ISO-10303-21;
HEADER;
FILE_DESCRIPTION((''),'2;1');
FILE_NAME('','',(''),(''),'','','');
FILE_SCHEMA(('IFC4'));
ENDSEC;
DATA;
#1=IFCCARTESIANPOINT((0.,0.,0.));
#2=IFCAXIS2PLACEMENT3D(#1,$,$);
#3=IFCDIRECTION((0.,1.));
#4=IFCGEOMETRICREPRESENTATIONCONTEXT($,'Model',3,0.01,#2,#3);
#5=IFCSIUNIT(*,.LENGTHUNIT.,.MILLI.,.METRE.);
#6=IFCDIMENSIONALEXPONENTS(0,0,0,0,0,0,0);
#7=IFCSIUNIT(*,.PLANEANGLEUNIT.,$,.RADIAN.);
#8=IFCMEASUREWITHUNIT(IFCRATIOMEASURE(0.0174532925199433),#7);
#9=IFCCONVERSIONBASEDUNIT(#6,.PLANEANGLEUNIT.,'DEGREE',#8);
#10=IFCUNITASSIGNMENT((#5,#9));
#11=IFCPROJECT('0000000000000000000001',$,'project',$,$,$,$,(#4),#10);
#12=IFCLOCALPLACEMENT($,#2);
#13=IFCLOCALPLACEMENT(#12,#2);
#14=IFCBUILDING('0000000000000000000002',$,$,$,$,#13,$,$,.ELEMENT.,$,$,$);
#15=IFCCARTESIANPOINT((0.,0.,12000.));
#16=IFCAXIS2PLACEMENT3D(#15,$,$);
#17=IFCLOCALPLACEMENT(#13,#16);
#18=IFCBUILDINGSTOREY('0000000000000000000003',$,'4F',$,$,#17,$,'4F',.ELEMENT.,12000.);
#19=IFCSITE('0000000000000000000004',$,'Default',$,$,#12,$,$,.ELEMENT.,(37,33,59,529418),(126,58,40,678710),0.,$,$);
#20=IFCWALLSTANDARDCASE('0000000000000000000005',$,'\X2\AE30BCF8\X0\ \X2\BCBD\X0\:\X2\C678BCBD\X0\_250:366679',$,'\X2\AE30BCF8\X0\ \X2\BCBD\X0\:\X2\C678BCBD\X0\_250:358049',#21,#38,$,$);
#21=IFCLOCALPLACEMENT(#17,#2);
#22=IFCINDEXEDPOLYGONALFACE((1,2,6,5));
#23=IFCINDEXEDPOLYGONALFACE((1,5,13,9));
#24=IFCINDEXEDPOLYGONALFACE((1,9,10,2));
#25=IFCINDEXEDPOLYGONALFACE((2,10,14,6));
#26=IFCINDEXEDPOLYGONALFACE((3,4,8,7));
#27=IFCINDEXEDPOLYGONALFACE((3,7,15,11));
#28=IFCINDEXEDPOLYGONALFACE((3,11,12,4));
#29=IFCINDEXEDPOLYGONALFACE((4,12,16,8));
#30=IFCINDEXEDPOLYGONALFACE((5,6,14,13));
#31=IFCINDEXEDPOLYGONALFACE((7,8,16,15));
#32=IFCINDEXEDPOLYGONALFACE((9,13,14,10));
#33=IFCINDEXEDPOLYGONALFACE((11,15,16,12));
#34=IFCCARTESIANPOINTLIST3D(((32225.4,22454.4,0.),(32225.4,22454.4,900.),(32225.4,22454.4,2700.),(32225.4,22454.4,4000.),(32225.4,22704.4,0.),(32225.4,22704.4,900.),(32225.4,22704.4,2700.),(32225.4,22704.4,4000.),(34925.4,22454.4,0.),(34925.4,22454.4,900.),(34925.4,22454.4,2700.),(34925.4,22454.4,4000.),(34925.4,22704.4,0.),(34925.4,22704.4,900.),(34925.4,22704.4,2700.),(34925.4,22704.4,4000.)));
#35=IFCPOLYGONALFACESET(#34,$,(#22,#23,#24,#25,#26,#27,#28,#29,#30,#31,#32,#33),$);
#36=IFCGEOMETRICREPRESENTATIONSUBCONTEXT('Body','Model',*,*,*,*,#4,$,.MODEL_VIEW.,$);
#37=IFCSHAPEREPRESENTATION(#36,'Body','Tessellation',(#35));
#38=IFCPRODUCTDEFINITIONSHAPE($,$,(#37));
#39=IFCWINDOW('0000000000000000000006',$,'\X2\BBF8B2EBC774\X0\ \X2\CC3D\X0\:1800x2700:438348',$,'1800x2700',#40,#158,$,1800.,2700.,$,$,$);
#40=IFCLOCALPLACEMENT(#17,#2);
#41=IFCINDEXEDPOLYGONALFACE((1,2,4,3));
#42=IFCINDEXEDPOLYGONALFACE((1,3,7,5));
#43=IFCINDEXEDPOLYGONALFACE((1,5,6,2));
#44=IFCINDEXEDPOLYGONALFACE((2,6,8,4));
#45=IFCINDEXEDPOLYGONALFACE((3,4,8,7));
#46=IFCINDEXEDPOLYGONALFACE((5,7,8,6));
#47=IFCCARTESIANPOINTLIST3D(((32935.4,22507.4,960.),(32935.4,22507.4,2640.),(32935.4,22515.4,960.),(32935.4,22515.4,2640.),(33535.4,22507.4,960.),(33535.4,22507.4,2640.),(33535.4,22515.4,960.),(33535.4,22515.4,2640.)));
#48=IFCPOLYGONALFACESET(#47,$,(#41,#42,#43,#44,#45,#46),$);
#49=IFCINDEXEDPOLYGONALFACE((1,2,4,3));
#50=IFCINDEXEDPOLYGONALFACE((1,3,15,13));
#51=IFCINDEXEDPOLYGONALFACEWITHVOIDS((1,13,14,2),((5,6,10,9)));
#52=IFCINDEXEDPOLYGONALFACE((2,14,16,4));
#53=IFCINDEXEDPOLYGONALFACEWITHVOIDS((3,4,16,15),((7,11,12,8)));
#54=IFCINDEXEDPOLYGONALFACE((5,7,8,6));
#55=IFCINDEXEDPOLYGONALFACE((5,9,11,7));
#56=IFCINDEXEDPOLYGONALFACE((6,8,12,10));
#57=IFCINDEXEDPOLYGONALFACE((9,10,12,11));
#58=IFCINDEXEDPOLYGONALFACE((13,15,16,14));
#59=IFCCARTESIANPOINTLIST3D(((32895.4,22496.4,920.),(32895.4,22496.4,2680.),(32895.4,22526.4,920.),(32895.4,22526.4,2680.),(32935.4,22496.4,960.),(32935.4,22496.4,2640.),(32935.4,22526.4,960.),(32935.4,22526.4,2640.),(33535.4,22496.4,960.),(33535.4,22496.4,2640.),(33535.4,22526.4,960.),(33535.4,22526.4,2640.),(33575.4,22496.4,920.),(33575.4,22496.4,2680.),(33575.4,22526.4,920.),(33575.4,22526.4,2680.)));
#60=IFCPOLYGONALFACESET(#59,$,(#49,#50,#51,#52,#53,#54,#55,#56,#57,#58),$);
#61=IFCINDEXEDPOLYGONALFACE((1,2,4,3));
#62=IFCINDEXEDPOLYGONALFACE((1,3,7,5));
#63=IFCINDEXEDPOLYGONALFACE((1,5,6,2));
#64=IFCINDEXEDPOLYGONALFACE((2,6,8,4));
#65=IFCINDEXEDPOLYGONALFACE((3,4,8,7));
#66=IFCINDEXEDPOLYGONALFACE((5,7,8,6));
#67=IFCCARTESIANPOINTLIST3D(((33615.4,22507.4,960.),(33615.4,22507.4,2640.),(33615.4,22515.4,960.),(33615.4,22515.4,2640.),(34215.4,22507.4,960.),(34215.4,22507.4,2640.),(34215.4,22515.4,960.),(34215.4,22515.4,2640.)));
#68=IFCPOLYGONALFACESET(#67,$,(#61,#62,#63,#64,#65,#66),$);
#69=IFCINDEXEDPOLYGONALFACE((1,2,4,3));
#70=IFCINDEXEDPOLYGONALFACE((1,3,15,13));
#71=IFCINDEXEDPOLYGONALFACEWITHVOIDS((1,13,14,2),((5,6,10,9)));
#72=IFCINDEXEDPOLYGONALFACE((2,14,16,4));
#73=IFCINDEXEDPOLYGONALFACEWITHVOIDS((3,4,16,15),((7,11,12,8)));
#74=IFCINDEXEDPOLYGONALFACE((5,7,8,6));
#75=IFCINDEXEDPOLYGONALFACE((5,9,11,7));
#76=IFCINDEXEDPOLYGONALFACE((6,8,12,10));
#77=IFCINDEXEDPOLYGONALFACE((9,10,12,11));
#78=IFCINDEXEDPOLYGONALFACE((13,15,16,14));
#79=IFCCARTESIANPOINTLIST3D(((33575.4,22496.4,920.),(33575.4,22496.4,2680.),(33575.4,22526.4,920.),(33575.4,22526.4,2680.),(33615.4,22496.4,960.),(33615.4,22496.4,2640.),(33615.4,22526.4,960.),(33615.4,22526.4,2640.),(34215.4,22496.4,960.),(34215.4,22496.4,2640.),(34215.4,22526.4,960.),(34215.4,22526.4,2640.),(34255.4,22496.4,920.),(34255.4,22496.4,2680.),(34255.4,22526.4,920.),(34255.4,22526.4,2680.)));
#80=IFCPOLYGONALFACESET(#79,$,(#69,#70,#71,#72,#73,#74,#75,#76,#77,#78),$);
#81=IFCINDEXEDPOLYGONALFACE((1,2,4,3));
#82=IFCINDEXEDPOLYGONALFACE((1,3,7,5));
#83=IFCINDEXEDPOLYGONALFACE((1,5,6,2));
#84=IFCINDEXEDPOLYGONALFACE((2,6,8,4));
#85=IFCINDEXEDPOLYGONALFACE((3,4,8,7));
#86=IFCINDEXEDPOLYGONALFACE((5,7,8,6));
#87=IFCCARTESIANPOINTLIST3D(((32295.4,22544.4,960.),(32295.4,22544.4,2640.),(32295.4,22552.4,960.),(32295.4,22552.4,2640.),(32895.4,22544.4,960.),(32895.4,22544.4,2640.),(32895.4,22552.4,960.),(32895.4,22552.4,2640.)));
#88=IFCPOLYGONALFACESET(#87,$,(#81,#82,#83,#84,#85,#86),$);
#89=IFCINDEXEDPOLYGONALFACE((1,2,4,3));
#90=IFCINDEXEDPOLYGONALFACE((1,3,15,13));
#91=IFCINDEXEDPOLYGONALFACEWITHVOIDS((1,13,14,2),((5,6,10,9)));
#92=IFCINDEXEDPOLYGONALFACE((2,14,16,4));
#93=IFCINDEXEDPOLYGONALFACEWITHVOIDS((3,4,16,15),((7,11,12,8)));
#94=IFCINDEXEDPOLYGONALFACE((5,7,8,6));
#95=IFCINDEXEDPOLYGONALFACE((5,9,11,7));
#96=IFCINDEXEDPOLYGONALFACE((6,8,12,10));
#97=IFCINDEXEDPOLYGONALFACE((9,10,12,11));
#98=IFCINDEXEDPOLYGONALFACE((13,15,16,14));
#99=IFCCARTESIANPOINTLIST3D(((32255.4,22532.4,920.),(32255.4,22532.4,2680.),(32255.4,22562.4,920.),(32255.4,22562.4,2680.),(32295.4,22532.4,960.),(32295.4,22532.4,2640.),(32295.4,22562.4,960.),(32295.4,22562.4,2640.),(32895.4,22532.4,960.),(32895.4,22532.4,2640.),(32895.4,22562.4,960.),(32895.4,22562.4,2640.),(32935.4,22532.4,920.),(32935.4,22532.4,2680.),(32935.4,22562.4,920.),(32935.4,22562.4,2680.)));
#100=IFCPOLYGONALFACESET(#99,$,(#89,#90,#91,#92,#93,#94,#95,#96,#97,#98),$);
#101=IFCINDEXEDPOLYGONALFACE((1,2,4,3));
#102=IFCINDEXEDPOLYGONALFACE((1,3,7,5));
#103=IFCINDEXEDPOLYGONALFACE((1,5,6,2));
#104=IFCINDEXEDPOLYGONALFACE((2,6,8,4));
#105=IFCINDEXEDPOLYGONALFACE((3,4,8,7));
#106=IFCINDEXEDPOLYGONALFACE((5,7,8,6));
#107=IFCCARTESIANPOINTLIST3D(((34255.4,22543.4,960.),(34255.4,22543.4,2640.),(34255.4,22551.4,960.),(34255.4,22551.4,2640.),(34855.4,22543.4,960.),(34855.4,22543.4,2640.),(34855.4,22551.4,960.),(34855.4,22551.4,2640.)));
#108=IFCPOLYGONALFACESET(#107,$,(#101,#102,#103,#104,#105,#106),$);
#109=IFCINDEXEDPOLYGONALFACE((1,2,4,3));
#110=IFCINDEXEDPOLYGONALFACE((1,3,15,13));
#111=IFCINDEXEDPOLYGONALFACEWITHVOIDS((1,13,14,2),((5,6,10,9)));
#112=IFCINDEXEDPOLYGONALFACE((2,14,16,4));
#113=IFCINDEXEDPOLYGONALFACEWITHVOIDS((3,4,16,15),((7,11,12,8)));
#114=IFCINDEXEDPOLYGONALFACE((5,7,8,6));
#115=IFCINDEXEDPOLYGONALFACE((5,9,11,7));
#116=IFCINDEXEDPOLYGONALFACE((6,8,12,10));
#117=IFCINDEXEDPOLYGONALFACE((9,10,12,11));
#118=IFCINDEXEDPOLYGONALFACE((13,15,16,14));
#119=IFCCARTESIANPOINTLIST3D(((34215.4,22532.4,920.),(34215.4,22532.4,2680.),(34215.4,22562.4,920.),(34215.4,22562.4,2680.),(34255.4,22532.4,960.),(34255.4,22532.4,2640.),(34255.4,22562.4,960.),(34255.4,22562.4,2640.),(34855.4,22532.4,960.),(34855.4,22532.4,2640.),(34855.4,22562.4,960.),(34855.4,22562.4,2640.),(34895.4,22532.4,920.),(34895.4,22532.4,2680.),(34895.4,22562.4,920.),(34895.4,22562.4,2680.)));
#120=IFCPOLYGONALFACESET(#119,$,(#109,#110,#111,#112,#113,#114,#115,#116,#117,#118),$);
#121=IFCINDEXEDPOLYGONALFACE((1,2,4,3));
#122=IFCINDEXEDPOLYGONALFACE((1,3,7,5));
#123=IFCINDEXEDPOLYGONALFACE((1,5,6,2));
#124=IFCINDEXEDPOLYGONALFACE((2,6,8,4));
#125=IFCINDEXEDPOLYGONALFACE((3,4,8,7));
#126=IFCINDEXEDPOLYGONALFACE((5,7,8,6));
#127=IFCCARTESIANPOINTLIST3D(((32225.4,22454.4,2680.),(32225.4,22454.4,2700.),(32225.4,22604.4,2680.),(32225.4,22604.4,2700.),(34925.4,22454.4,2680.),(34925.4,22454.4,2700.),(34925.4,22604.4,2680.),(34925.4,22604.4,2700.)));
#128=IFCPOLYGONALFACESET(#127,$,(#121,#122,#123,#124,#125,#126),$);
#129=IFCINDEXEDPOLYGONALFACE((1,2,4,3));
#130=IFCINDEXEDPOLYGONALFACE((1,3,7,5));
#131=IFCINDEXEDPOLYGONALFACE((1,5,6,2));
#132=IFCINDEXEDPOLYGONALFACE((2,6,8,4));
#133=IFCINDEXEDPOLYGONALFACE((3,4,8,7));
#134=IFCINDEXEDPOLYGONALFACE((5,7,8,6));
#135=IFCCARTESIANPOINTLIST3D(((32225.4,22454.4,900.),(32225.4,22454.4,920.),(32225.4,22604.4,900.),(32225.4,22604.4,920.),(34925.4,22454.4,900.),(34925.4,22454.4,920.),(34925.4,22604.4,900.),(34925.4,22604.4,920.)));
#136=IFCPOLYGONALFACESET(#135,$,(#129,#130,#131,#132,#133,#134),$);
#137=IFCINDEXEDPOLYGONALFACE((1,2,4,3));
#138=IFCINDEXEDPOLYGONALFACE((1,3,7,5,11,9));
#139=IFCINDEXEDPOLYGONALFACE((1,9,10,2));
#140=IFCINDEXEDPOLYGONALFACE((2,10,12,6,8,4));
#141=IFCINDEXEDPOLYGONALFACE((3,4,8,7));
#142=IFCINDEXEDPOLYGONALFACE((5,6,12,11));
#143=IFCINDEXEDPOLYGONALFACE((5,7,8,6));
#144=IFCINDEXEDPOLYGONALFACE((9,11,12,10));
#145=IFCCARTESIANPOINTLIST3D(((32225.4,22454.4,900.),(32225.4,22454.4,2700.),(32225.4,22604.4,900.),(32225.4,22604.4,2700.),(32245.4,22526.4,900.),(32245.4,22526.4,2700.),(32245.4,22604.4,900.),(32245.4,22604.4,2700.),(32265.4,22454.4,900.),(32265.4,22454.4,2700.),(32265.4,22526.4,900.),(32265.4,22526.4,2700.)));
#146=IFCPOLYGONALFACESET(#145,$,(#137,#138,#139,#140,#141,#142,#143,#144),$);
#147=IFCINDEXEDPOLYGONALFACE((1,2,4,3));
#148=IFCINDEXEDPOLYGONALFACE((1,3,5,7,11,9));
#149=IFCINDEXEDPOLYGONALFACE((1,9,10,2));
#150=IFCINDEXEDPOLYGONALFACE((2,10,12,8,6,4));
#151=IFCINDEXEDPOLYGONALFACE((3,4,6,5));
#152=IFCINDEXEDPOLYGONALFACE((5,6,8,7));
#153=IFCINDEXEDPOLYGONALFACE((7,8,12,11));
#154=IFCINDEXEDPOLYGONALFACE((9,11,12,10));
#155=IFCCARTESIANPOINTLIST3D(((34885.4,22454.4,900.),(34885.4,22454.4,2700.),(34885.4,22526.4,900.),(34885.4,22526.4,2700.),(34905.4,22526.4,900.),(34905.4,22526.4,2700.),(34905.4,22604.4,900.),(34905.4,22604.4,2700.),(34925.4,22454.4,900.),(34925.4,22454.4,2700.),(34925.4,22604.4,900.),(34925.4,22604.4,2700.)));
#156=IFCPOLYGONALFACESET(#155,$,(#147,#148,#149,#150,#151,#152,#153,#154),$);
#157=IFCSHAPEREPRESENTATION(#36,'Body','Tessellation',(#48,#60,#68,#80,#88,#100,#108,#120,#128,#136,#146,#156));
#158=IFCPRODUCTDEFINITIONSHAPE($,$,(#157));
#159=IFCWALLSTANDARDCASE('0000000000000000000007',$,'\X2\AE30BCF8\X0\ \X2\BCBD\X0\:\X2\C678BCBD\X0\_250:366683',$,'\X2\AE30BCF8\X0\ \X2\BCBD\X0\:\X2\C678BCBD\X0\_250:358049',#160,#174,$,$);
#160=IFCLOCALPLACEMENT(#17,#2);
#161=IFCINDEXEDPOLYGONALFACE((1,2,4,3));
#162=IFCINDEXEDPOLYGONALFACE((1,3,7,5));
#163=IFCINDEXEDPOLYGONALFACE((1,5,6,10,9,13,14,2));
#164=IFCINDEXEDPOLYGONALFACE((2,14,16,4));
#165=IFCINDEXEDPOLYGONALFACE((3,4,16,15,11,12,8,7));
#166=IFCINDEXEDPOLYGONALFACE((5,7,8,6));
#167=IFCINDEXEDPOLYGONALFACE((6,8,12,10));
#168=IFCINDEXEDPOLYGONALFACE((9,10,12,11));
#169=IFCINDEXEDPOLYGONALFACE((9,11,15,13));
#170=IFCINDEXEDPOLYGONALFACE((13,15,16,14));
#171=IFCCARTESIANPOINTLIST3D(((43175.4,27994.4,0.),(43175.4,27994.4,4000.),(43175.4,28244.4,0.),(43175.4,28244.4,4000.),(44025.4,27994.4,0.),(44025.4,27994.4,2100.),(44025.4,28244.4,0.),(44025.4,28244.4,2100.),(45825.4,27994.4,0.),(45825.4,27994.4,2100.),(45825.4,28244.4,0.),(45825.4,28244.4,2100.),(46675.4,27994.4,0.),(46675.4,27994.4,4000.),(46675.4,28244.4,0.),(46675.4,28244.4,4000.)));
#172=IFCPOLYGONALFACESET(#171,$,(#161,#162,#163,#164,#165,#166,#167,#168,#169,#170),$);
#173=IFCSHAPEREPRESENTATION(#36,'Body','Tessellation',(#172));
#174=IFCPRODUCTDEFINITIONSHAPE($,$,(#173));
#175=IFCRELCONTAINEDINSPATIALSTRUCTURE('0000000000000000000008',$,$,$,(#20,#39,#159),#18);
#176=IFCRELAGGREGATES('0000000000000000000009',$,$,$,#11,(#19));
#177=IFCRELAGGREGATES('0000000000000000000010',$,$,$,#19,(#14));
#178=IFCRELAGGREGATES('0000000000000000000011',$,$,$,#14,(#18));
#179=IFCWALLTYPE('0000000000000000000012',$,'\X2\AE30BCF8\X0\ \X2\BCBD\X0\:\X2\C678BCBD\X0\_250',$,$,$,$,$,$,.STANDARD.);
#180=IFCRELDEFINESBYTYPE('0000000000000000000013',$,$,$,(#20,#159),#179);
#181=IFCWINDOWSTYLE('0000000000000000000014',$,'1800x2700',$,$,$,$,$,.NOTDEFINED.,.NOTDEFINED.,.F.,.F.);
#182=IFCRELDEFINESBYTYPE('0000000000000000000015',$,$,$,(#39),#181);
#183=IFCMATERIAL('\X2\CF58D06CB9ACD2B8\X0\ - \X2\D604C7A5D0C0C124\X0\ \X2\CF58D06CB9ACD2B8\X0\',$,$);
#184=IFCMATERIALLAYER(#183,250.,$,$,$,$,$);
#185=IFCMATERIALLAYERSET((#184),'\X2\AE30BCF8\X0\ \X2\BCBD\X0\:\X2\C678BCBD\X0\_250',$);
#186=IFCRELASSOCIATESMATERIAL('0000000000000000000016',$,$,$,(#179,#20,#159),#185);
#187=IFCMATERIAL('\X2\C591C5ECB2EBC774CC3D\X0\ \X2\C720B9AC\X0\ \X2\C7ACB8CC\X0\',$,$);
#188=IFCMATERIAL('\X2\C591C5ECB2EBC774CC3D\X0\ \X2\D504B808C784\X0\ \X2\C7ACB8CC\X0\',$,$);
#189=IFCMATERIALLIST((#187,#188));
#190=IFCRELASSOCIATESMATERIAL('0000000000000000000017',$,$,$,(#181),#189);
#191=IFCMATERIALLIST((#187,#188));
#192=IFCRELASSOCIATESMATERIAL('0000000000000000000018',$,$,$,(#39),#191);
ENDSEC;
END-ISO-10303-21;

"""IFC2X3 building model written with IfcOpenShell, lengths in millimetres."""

from ifc_helpers import new_model, entity, si_unit, converted_unit, direction, frame, frame_2d, origin, origin_2d_with_axis, place, context, subcontext, project, spatial, polyline, rectangle, outline, extrude, source, transform, mapped, material, material_list, layer, layer_set, layer_usage, type_object, type_shapes, element, fill, save


model = new_model("IFC2X3")

# Units and contexts
model_context = context("Model", 3, precision=0.01, world=origin(), true_north=direction((0.0, 1.0)))
body_context = subcontext(model_context, "Body", "Model", "MODEL_VIEW")
ifc_project = project(units=[si_unit("LENGTHUNIT", "METRE", prefix="MILLI"), converted_unit("PLANEANGLEUNIT", "DEGREE", entity("IfcRatioMeasure", 0.0174532925199433), si_unit("PLANEANGLEUNIT", "RADIAN"), dimensions=[0, 0, 0, 0, 0, 0, 0])], contexts=[model_context])

# Site, building, storey
site_placement = place(None, origin())
site = spatial("IfcSite", under=ifc_project, at=site_placement, Name="Default", CompositionType="ELEMENT", RefLatitude=(37, 33, 59, 529418), RefLongitude=(126, 58, 40, 678710), RefElevation=0.0)
building_placement = place(site_placement, origin())
building = spatial("IfcBuilding", under=site, at=building_placement, CompositionType="ELEMENT")
storey_placement = place(building_placement, frame((0.0, 0.0, 12000.0)))
storey = spatial("IfcBuildingStorey", under=building, at=storey_placement, Name="4F", LongName="4F", CompositionType="ELEMENT", Elevation=12000.0)

# Shared definitions
ifc_material_1 = material(Name="콘크리트 - 현장타설 콘크리트")
ifc_material_2 = material(Name="양여닫이창 유리 재료")
ifc_material_3 = material(Name="양여닫이창 프레임 재료")

# Wall, opening, window
ifc_layer_1 = layer(ifc_material_1, 250.0)
ifc_layer_set_1 = layer_set([ifc_layer_1], Name="기본 벽:외벽_250")
ifc_layer_usage_1 = layer_usage(ifc_layer_set_1, "AXIS2", "NEGATIVE", 125.0)
wall_type_1 = type_object("IfcWallType", Name="기본 벽:외벽_250", PredefinedType="STANDARD", material=ifc_layer_set_1)
wall_1_placement = place(storey_placement, frame((34925.4, 22579.4, 0.0), z_axis=(0.0, 0.0, 1.0), x_axis=(-1.0, 0.0, 0.0)))
wall_1 = element("IfcWallStandardCase", 1, at=wall_1_placement, inside=storey, type_object=wall_type_1, material=ifc_layer_usage_1, Name="기본 벽:외벽_250:366679", ObjectType="기본 벽:외벽_250:358049", context=body_context, shape_type="SweptSolid", body=[
    extrude(rectangle(XDim=2700.0, YDim=250.0, at=frame_2d((1350.0, 0.0), x_axis=(-1.0, 0.0))), origin(), (0.0, 0.0, 1.0), 4000.0),
])
opening_1_placement = place(wall_1_placement, frame((0.0, -125.0, 900.0)))
opening_1 = element("IfcOpeningElement", 2, at=opening_1_placement, cuts=wall_1, ObjectType="Opening", context=body_context, shape_type="SweptSolid", body=[
    extrude(rectangle(XDim=1800.0, YDim=2700.0, at=frame_2d((900.0, 1350.0), x_axis=(1.0, 0.0))), frame((0.0, 0.0, 0.0), z_axis=(0.0, 1.0, 0.0), x_axis=(0.0, 0.0, 1.0)), (0.0, 0.0, 1.0), 250.0),
])
ifc_material_list_1 = material_list([ifc_material_2, ifc_material_3])
ifc_material_list_2 = material_list([ifc_material_2, ifc_material_3])
window_style_1 = type_object("IfcWindowStyle", Name="1800x2700", ConstructionType="NOTDEFINED", OperationType="NOTDEFINED", ParameterTakesPrecedence=False, Sizeable=False, material=ifc_material_list_2)
shared_shape_1 = source(origin(), body_context, "Body", "SweptSolid", [
    extrude(rectangle(XDim=8.0, YDim=600.0, at=frame_2d((0.0, 0.0), x_axis=(1.0, 0.0))), frame((1690.0, 193.0, 60.0), z_axis=(0.0, 0.0, 1.0), x_axis=(0.0, 1.0, 0.0)), (0.0, 0.0, 1.0), 1680.0),
    extrude(outline(polyline([(-880.0, -340.0), (880.0, -340.0), (880.0, 340.0), (-880.0, 340.0), (-880.0, -340.0)]), holes=[polyline([(840.0, -300.0), (-840.0, -300.0), (-840.0, 300.0), (840.0, 300.0), (840.0, -300.0)])]), frame((1690.0, 178.0, 900.0), z_axis=(0.0, 1.0, 0.0), x_axis=(0.0, 0.0, -1.0)), (0.0, 0.0, 1.0), 30.0),
    extrude(rectangle(XDim=8.0, YDim=600.0, at=origin_2d_with_axis()), frame((1010.0, 193.0, 60.0), z_axis=(0.0, 0.0, 1.0), x_axis=(0.0, 1.0, 0.0)), (0.0, 0.0, 1.0), 1680.0),
    extrude(outline(polyline([(-880.0, -340.0), (880.0, -340.0), (880.0, 340.0), (-880.0, 340.0), (-880.0, -340.0)]), holes=[polyline([(840.0, -300.0), (-840.0, -300.0), (-840.0, 300.0), (840.0, 300.0), (840.0, -300.0)])]), frame((1010.0, 178.0, 900.0), z_axis=(0.0, 1.0, 0.0), x_axis=(0.0, 0.0, -1.0)), (0.0, 0.0, 1.0), 30.0),
    extrude(rectangle(XDim=8.0, YDim=600.0, at=frame_2d((0.0, 0.0), x_axis=(1.0, 0.0))), frame((2330.0, 156.0, 60.0), z_axis=(0.0, 0.0, 1.0), x_axis=(0.0, 1.0, 0.0)), (0.0, 0.0, 1.0), 1680.0),
    extrude(outline(polyline([(-880.0, -340.0), (880.0, -340.0), (880.0, 340.0), (-880.0, 340.0), (-880.0, -340.0)]), holes=[polyline([(840.0, -300.0), (-840.0, -300.0), (-840.0, 300.0), (840.0, 300.0), (840.0, -300.0)])]), frame((2330.0, 142.0, 900.0), z_axis=(0.0, 1.0, 0.0), x_axis=(0.0, 0.0, -1.0)), (0.0, 0.0, 1.0), 30.0),
    extrude(rectangle(XDim=8.0, YDim=600.0, at=frame_2d((0.0, 0.0), x_axis=(1.0, 0.0))), frame((370.0, 157.0, 60.0), z_axis=(0.0, 0.0, 1.0), x_axis=(0.0, 1.0, 0.0)), (0.0, 0.0, 1.0), 1680.0),
    extrude(outline(polyline([(-880.0, -340.0), (880.0, -340.0), (880.0, 340.0), (-880.0, 340.0), (-880.0, -340.0)]), holes=[polyline([(840.0, -300.0), (-840.0, -300.0), (-840.0, 300.0), (840.0, 300.0), (840.0, -300.0)])]), frame((370.0, 142.0, 900.0), z_axis=(0.0, 1.0, 0.0), x_axis=(0.0, 0.0, -1.0)), (0.0, 0.0, 1.0), 30.0),
    extrude(rectangle(XDim=2700.0, YDim=150.0, at=origin_2d_with_axis()), frame((1350.0, 175.0, 1780.0), z_axis=(0.0, 0.0, 1.0), x_axis=(-1.0, 0.0, 0.0)), (0.0, 0.0, 1.0), 20.0),
    extrude(rectangle(XDim=2700.0, YDim=150.0, at=origin_2d_with_axis()), frame((1350.0, 175.0, 0.0), z_axis=(0.0, 0.0, 1.0), x_axis=(-1.0, 0.0, 0.0)), (0.0, 0.0, 1.0), 20.0),
    extrude(outline(polyline([(-74.0, -20.0), (-2.0, -20.0), (-2.0, 0.0), (76.0, 0.0), (76.0, 20.0), (-74.0, 20.0), (-74.0, -20.0)])), frame((2680.0, 176.0, 0.0), z_axis=(0.0, 0.0, 1.0), x_axis=(0.0, -1.0, 0.0)), (0.0, 0.0, 1.0), 1800.0),
    extrude(outline(polyline([(-20.0, -74.0), (20.0, -74.0), (20.0, 76.0), (0.0, 76.0), (0.0, -2.0), (-20.0, -2.0), (-20.0, -74.0)])), frame((20.0, 176.0, 0.0), z_axis=(0.0, 0.0, 1.0), x_axis=(-1.0, 0.0, 0.0)), (0.0, 0.0, 1.0), 1800.0),
])
type_shapes(window_style_1, [shared_shape_1])
window_1_placement = place(opening_1_placement, origin())
window_1 = element("IfcWindow", 3, at=window_1_placement, inside=storey, type_object=window_style_1, material=ifc_material_list_1, Name="미닫이 창:1800x2700:438348", ObjectType="1800x2700", OverallHeight=1800.0, OverallWidth=2700.0, context=body_context, shape_type="MappedRepresentation", body=[
    mapped(shared_shape_1, transform((0.0, 0.0, 0.0), scale=1.0)),
])
fill(opening_1, window_1)

# Wall, opening
ifc_layer_usage_2 = layer_usage(ifc_layer_set_1, "AXIS2", "NEGATIVE", 125.0)
wall_2_placement = place(storey_placement, frame((46675.4, 28119.4, 0.0), z_axis=(0.0, 0.0, 1.0), x_axis=(-1.0, 0.0, 0.0)))
wall_2 = element("IfcWallStandardCase", 4, at=wall_2_placement, inside=storey, type_object=wall_type_1, material=ifc_layer_usage_2, Name="기본 벽:외벽_250:366683", ObjectType="기본 벽:외벽_250:358049", context=body_context, shape_type="SweptSolid", body=[
    extrude(rectangle(XDim=3500.0, YDim=250.0, at=frame_2d((1750.0, 0.0), x_axis=(-1.0, 0.0))), origin(), (0.0, 0.0, 1.0), 4000.0),
])
opening_2_placement = place(wall_2_placement, frame((850.0, -125.0, 0.0)))
element("IfcOpeningElement", 5, at=opening_2_placement, cuts=wall_2, ObjectType="Opening", context=body_context, shape_type="SweptSolid", body=[
    extrude(rectangle(XDim=2100.0, YDim=1800.0, at=frame_2d((1050.0, 900.0), x_axis=(1.0, 0.0))), frame((0.0, 0.0, 0.0), z_axis=(0.0, 1.0, 0.0), x_axis=(0.0, 0.0, 1.0)), (0.0, 0.0, 1.0), 250.0),
])

save(model, "model.ifc")
